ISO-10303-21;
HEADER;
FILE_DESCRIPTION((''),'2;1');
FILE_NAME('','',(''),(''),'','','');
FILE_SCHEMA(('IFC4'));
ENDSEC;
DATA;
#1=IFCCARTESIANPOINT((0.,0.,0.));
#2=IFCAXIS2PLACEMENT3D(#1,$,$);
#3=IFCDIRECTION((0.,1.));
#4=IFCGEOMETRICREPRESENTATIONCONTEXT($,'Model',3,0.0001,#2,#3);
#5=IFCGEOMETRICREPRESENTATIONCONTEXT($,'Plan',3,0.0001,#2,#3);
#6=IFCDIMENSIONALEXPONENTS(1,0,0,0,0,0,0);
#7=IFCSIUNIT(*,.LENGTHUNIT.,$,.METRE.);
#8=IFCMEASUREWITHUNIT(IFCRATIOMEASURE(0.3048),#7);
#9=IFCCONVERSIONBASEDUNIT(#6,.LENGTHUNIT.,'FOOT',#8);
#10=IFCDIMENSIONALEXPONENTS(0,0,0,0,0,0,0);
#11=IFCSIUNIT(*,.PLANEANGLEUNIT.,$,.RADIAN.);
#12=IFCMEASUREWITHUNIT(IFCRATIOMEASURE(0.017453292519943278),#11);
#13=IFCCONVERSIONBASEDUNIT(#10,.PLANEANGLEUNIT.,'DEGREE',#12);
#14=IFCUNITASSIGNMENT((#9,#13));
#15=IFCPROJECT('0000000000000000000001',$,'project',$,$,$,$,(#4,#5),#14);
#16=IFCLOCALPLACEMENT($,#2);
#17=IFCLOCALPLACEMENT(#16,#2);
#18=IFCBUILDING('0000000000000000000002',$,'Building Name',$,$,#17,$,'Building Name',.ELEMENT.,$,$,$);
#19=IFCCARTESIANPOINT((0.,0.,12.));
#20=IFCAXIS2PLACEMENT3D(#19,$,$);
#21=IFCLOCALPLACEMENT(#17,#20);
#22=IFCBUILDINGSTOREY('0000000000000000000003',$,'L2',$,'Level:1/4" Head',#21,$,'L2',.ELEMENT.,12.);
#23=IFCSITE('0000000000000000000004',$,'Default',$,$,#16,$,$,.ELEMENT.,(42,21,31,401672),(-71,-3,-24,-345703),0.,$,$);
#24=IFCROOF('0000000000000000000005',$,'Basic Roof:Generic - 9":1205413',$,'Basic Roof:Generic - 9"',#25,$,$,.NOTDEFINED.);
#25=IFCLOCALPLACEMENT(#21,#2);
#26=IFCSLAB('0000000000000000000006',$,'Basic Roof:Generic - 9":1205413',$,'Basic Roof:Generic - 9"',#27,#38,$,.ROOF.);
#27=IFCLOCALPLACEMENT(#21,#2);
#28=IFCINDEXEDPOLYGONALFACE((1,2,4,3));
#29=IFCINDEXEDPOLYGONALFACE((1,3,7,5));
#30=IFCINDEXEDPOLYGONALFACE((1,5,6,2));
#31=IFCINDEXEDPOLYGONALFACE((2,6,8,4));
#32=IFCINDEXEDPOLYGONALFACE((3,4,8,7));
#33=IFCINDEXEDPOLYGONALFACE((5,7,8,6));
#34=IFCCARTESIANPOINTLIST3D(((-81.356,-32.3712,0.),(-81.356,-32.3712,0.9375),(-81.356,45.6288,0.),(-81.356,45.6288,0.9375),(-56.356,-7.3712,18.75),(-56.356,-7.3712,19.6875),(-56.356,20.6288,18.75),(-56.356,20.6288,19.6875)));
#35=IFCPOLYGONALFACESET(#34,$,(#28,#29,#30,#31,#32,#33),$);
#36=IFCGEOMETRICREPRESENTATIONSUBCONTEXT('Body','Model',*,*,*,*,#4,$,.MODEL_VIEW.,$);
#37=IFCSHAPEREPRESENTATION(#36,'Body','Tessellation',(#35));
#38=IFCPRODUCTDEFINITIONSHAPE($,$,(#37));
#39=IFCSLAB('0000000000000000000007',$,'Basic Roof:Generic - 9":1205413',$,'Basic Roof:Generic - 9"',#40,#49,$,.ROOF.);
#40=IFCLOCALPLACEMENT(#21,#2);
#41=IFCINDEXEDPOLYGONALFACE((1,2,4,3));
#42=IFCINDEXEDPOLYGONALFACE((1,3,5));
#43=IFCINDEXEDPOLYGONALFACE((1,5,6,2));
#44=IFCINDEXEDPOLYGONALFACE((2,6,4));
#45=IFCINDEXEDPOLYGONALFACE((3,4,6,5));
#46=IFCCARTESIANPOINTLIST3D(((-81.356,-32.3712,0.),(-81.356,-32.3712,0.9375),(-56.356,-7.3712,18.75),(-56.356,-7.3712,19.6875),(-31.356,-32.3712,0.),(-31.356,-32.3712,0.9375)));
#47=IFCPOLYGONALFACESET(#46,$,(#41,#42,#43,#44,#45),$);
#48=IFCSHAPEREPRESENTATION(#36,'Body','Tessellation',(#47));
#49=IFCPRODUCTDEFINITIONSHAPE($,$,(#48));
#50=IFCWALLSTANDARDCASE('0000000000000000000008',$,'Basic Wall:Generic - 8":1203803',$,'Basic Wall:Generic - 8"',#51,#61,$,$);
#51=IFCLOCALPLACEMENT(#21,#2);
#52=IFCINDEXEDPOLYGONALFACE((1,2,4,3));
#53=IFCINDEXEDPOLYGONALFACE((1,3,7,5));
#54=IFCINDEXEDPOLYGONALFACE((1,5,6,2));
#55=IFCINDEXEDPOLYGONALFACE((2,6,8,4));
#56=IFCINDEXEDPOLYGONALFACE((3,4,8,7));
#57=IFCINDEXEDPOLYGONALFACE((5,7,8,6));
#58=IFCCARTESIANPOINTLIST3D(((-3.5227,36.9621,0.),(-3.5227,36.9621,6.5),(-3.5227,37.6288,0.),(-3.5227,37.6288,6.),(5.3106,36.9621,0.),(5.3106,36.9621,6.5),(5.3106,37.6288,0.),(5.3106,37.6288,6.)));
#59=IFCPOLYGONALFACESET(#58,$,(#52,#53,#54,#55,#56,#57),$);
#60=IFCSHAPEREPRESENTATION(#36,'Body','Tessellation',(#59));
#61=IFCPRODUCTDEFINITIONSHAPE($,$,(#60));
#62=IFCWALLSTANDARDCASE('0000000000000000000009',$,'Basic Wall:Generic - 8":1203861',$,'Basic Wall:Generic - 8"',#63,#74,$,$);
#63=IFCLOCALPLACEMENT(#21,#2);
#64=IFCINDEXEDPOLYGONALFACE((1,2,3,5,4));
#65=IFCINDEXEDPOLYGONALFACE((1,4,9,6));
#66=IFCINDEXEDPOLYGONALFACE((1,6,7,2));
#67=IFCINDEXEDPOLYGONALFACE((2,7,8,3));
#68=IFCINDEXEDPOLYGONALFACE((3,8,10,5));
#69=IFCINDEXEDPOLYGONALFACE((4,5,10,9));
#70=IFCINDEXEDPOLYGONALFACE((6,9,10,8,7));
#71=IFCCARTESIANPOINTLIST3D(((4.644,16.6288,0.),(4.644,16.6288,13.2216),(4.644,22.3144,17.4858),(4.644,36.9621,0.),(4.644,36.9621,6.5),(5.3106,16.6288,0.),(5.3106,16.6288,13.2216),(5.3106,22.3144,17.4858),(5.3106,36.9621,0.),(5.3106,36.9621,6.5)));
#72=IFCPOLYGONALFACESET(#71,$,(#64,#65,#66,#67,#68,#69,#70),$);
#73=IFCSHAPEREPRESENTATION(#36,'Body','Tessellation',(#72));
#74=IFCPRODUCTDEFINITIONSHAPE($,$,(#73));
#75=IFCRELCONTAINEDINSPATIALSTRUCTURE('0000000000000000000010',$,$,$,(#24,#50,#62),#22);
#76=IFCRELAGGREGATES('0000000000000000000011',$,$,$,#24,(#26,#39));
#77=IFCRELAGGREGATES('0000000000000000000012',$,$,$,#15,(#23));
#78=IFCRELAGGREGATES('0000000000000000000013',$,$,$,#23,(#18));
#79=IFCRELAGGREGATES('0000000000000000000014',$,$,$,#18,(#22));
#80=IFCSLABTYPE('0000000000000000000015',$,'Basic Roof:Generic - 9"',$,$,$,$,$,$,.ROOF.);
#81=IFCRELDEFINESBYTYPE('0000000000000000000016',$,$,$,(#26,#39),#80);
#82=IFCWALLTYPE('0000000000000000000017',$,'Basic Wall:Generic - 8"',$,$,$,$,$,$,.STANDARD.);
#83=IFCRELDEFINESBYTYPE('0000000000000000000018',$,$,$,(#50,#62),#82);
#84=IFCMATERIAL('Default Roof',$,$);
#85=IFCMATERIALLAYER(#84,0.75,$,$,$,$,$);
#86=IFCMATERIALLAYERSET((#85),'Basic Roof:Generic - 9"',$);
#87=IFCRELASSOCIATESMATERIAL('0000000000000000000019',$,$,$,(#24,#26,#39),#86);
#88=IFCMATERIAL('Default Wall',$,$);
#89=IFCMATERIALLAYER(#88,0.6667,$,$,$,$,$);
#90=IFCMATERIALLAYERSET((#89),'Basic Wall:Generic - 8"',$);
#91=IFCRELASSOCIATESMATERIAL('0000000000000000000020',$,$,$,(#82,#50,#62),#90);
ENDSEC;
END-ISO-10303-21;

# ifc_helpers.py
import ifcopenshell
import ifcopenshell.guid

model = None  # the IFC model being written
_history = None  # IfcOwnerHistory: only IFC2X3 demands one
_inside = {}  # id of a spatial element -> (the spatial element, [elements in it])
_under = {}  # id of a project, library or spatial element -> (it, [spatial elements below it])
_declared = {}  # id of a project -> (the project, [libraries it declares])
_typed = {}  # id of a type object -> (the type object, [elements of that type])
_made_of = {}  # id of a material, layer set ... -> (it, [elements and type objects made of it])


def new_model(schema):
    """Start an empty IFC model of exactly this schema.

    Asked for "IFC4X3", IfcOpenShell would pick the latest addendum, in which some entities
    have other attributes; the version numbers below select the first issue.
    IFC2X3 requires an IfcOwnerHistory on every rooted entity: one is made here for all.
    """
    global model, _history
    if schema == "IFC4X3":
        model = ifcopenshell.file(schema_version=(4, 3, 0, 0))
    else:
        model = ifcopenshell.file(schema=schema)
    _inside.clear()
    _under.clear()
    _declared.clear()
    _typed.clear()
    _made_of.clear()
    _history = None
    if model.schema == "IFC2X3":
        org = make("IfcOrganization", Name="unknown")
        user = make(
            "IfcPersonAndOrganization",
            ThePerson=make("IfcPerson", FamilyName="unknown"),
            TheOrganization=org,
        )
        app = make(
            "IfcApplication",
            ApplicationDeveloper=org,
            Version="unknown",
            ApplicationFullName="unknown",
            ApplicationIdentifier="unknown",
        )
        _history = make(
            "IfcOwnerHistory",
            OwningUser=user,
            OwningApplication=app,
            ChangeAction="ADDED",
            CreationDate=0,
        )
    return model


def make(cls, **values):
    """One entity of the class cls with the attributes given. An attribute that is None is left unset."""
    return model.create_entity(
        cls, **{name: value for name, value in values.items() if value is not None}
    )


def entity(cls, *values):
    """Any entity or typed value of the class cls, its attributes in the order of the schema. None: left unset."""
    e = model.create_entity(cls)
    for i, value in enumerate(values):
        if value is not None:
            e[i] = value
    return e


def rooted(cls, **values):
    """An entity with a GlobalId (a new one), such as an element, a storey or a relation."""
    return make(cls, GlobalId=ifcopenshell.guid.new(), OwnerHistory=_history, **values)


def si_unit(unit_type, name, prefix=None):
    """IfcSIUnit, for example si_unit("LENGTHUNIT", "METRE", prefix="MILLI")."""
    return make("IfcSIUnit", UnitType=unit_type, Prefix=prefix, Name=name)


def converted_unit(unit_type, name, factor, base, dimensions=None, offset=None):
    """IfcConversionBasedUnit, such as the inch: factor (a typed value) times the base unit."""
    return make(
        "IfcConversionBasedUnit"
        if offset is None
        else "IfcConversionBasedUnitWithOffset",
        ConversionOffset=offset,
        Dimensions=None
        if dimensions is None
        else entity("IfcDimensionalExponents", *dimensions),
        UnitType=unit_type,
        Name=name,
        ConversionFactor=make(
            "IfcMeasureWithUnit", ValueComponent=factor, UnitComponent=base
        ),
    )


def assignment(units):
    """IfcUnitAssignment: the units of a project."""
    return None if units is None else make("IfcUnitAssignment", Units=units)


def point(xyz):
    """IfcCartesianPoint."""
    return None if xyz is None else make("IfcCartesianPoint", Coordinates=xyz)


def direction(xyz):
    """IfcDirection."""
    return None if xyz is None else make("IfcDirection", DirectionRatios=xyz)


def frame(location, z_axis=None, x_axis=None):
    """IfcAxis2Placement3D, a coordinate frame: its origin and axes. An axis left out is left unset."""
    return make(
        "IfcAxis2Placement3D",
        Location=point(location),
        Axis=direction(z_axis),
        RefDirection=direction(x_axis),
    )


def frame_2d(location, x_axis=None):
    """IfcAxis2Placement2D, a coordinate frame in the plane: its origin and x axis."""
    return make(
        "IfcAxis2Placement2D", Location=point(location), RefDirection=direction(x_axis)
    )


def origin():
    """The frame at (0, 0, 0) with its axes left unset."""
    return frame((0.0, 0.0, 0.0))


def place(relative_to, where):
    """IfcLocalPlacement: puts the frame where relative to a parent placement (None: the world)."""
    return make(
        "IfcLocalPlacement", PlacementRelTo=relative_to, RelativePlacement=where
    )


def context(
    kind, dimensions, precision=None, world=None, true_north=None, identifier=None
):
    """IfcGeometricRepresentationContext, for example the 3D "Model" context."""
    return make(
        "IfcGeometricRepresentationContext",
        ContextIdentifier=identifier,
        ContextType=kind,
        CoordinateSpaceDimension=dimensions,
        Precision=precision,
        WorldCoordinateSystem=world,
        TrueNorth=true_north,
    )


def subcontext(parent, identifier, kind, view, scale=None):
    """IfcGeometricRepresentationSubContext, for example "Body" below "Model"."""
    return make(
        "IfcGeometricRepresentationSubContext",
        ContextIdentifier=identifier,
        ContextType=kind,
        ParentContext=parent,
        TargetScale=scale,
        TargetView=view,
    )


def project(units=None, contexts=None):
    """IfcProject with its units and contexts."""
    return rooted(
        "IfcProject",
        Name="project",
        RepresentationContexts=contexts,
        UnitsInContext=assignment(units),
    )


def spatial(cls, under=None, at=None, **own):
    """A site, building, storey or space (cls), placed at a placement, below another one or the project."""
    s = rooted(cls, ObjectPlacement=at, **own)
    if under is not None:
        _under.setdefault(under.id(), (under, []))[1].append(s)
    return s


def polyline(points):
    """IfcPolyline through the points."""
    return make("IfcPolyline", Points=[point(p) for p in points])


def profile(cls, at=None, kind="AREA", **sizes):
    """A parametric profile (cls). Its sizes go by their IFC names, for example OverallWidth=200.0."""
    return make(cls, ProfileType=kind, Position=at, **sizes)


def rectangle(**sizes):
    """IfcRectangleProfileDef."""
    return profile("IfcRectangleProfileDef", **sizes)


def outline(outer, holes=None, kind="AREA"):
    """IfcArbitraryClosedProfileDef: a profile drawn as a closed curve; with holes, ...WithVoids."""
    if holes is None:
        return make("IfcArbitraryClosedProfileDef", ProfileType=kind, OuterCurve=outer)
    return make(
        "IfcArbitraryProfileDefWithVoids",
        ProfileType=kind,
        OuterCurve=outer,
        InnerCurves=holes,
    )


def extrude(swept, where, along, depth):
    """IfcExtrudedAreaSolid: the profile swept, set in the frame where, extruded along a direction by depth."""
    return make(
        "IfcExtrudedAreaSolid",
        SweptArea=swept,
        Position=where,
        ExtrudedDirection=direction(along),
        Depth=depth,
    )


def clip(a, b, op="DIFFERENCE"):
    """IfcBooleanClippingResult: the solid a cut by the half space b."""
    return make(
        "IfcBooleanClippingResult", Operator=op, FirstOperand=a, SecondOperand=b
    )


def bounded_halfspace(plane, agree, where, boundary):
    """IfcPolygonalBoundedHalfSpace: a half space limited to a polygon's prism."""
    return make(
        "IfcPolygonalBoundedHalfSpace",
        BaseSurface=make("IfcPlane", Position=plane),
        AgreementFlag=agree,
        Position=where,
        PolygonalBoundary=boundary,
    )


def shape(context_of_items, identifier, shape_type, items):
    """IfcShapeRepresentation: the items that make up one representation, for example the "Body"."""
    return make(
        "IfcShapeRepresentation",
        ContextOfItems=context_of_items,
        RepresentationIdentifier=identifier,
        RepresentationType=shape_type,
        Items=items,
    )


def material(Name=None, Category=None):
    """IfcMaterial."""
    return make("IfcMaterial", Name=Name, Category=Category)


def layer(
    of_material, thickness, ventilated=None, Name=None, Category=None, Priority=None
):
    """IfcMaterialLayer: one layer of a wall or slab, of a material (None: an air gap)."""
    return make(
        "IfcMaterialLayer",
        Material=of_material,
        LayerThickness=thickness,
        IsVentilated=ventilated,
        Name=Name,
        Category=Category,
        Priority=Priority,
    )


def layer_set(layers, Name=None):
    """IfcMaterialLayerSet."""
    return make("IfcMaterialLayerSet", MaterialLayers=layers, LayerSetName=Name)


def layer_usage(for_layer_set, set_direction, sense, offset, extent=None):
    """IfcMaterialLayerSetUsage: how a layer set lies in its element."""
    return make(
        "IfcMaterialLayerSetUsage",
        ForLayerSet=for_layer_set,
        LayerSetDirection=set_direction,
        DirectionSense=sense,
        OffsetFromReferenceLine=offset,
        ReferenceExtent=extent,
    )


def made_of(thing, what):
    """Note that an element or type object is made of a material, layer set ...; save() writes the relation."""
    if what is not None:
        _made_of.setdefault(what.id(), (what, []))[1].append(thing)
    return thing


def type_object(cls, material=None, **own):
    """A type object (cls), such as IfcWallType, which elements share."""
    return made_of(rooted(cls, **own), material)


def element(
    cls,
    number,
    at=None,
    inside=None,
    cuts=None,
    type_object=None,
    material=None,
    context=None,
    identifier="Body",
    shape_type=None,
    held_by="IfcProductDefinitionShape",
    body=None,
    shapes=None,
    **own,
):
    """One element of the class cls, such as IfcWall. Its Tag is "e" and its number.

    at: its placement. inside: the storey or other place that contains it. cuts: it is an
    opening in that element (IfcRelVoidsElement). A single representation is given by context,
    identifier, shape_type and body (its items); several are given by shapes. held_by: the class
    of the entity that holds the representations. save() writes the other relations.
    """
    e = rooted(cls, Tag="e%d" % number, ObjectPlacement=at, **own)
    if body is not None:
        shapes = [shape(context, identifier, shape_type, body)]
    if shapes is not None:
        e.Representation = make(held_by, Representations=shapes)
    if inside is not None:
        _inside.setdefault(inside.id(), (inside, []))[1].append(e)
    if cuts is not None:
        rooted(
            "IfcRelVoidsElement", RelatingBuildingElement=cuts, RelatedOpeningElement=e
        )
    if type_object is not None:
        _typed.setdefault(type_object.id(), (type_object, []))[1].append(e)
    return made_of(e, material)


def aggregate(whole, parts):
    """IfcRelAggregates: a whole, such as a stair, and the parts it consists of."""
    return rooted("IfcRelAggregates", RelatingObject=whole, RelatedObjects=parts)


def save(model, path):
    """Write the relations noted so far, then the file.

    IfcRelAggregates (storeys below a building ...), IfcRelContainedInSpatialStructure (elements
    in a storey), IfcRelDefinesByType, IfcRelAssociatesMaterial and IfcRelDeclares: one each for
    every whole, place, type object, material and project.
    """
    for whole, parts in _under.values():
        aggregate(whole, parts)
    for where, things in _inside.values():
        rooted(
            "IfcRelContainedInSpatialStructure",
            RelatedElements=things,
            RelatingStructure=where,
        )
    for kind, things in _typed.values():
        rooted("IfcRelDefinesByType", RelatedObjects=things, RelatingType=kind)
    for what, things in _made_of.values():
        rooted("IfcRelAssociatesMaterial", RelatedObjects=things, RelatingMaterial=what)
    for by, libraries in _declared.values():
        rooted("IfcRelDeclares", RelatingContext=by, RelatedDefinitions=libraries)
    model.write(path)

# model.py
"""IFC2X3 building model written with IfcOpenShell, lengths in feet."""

from ifc_helpers import new_model, entity, si_unit, converted_unit, direction, frame, frame_2d, origin, place, context, subcontext, project, spatial, polyline, rectangle, outline, extrude, clip, bounded_halfspace, material, layer, layer_set, layer_usage, type_object, element, aggregate, save


model = new_model("IFC2X3")

# Units and contexts
model_context = context("Model", 3, precision=0.0001, world=origin(), true_north=direction((0.0, 1.0)))
plan_context = context("Plan", 3, precision=0.0001, world=origin(), true_north=direction((0.0, 1.0)))
body_context = subcontext(model_context, "Body", "Model", "MODEL_VIEW")
ifc_project = project(units=[converted_unit("LENGTHUNIT", "FOOT", entity("IfcRatioMeasure", 0.3048), si_unit("LENGTHUNIT", "METRE"), dimensions=[1, 0, 0, 0, 0, 0, 0]), converted_unit("PLANEANGLEUNIT", "DEGREE", entity("IfcRatioMeasure", 0.017453292519943278), si_unit("PLANEANGLEUNIT", "RADIAN"), dimensions=[0, 0, 0, 0, 0, 0, 0])], contexts=[model_context, plan_context])

# Site, building, storey
site_placement = place(None, origin())
site = spatial("IfcSite", under=ifc_project, at=site_placement, Name="Default", CompositionType="ELEMENT", RefLatitude=(42, 21, 31, 401672), RefLongitude=(-71, -3, -24, -345703), RefElevation=0.0)
building_placement = place(site_placement, origin())
building = spatial("IfcBuilding", under=site, at=building_placement, Name="Building Name", LongName="Building Name", CompositionType="ELEMENT")
storey_placement = place(building_placement, frame((0.0, 0.0, 12.0)))
storey = spatial("IfcBuildingStorey", under=building, at=storey_placement, Name="L2", ObjectType="Level:1/4\" Head", LongName="L2", CompositionType="ELEMENT", Elevation=12.0)

# Roof, slabs
ifc_material_1 = material(Name="Default Roof")
ifc_layer_1 = layer(ifc_material_1, 0.75)
ifc_layer_set_1 = layer_set([ifc_layer_1], Name="Basic Roof:Generic - 9\"")
roof_placement = place(storey_placement, frame((-81.356, -32.3712, 0.0)))
roof = element("IfcRoof", 1, at=roof_placement, inside=storey, material=ifc_layer_set_1, Name="Basic Roof:Generic - 9\":1205413", ObjectType="Basic Roof:Generic - 9\"", ShapeType="NOTDEFINED")
slab_type_1 = type_object("IfcSlabType", Name="Basic Roof:Generic - 9\"", PredefinedType="ROOF")
slab_1_placement = place(roof_placement, origin())
slab_1 = element("IfcSlab", 2, at=slab_1_placement, type_object=slab_type_1, material=ifc_layer_set_1, Name="Basic Roof:Generic - 9\":1205413", ObjectType="Basic Roof:Generic - 9\"", PredefinedType="ROOF", context=body_context, shape_type="SweptSolid", body=[
    extrude(outline(polyline([(15.625, -14.0), (15.625, 14.0), (-15.625, 39.0), (-15.625, -39.0), (15.625, -14.0)])), frame((12.5, 39.0, 9.375), z_axis=(-0.6, 0.0, 0.8), x_axis=(0.8, 0.0, 0.6)), (0.6, 0.0, 0.8), 0.9375),
])
slab_2_placement = place(roof_placement, origin())
slab_2 = element("IfcSlab", 3, at=slab_2_placement, type_object=slab_type_1, material=ifc_layer_set_1, Name="Basic Roof:Generic - 9\":1205413", ObjectType="Basic Roof:Generic - 9\"", PredefinedType="ROOF", context=body_context, shape_type="SweptSolid", body=[
    extrude(outline(polyline([(-25.0, -15.625), (25.0, -15.625), (0.0, 15.625), (-25.0, -15.625)])), frame((25.0, 12.5, 9.375), z_axis=(0.0, -0.6, 0.8), x_axis=(1.0, 0.0, 0.0)), (0.0, 0.6, 0.8), 0.9375),
])
aggregate(roof, [slab_1, slab_2])

# Walls
ifc_material_2 = material(Name="Default Wall")
ifc_layer_2 = layer(ifc_material_2, 0.6667)
ifc_layer_set_2 = layer_set([ifc_layer_2], Name="Basic Wall:Generic - 8\"")
ifc_layer_usage_1 = layer_usage(ifc_layer_set_2, "AXIS2", "NEGATIVE", 0.3333)
wall_type = type_object("IfcWallType", Name="Basic Wall:Generic - 8\"", PredefinedType="STANDARD", material=ifc_layer_set_2)
wall_1_placement = place(storey_placement, frame((-3.5227, 37.2955, 0.0)))
element("IfcWallStandardCase", 4, at=wall_1_placement, inside=storey, type_object=wall_type, material=ifc_layer_usage_1, Name="Basic Wall:Generic - 8\":1203803", ObjectType="Basic Wall:Generic - 8\"", context=body_context, shape_type="Clipping", body=[
    clip(extrude(rectangle(XDim=8.8333, YDim=0.6667, at=frame_2d((4.4167, 0.0), x_axis=(-1.0, 0.0))), origin(), (0.0, 0.0, 1.0), 6.5), bounded_halfspace(frame((0.0, -0.3333, 6.5), z_axis=(0.0, 0.6, 0.8), x_axis=(-1.0, 0.0, 0.0)), False, frame((0.0, -0.3333, 6.5)), polyline([(0.0, 0.0), (8.1667, 0.0), (8.8333, 0.0), (8.8333, 0.6667), (0.0, 0.6667), (0.0, 0.0)]))),
])
wall_2_placement = place(storey_placement, frame((4.9773, 36.9621, 0.0), z_axis=(0.0, 0.0, 1.0), x_axis=(0.0, -1.0, 0.0)))
element("IfcWallStandardCase", 5, at=wall_2_placement, inside=storey, type_object=wall_type, material=ifc_layer_usage_1, Name="Basic Wall:Generic - 8\":1203861", ObjectType="Basic Wall:Generic - 8\"", context=body_context, shape_type="Clipping", body=[
    clip(clip(extrude(rectangle(XDim=20.3333, YDim=0.6667, at=frame_2d((10.1667, 0.0), x_axis=(-1.0, 0.0))), origin(), (0.0, 0.0, 1.0), 17.4858), bounded_halfspace(frame((14.6477, -0.3333, 17.4858), z_axis=(0.6, 0.0, 0.8), x_axis=(0.0, 1.0, 0.0)), False, frame((14.6477, -0.3333, 17.4858)), polyline([(0.0, 0.0), (5.6856, 0.0), (5.6856, 0.6667), (0.0, 0.6667), (0.0, 0.0)]))), bounded_halfspace(frame((0.0, -0.3333, 6.5), z_axis=(-0.6, 0.0, 0.8), x_axis=(0.0, -1.0, 0.0)), False, frame((0.0, -0.3333, 6.5)), polyline([(0.0, 0.0), (14.6477, 0.0), (14.6477, 0.6667), (0.0, 0.6667), (0.0, 0.0)]))),
])

save(model, "model.ifc")
